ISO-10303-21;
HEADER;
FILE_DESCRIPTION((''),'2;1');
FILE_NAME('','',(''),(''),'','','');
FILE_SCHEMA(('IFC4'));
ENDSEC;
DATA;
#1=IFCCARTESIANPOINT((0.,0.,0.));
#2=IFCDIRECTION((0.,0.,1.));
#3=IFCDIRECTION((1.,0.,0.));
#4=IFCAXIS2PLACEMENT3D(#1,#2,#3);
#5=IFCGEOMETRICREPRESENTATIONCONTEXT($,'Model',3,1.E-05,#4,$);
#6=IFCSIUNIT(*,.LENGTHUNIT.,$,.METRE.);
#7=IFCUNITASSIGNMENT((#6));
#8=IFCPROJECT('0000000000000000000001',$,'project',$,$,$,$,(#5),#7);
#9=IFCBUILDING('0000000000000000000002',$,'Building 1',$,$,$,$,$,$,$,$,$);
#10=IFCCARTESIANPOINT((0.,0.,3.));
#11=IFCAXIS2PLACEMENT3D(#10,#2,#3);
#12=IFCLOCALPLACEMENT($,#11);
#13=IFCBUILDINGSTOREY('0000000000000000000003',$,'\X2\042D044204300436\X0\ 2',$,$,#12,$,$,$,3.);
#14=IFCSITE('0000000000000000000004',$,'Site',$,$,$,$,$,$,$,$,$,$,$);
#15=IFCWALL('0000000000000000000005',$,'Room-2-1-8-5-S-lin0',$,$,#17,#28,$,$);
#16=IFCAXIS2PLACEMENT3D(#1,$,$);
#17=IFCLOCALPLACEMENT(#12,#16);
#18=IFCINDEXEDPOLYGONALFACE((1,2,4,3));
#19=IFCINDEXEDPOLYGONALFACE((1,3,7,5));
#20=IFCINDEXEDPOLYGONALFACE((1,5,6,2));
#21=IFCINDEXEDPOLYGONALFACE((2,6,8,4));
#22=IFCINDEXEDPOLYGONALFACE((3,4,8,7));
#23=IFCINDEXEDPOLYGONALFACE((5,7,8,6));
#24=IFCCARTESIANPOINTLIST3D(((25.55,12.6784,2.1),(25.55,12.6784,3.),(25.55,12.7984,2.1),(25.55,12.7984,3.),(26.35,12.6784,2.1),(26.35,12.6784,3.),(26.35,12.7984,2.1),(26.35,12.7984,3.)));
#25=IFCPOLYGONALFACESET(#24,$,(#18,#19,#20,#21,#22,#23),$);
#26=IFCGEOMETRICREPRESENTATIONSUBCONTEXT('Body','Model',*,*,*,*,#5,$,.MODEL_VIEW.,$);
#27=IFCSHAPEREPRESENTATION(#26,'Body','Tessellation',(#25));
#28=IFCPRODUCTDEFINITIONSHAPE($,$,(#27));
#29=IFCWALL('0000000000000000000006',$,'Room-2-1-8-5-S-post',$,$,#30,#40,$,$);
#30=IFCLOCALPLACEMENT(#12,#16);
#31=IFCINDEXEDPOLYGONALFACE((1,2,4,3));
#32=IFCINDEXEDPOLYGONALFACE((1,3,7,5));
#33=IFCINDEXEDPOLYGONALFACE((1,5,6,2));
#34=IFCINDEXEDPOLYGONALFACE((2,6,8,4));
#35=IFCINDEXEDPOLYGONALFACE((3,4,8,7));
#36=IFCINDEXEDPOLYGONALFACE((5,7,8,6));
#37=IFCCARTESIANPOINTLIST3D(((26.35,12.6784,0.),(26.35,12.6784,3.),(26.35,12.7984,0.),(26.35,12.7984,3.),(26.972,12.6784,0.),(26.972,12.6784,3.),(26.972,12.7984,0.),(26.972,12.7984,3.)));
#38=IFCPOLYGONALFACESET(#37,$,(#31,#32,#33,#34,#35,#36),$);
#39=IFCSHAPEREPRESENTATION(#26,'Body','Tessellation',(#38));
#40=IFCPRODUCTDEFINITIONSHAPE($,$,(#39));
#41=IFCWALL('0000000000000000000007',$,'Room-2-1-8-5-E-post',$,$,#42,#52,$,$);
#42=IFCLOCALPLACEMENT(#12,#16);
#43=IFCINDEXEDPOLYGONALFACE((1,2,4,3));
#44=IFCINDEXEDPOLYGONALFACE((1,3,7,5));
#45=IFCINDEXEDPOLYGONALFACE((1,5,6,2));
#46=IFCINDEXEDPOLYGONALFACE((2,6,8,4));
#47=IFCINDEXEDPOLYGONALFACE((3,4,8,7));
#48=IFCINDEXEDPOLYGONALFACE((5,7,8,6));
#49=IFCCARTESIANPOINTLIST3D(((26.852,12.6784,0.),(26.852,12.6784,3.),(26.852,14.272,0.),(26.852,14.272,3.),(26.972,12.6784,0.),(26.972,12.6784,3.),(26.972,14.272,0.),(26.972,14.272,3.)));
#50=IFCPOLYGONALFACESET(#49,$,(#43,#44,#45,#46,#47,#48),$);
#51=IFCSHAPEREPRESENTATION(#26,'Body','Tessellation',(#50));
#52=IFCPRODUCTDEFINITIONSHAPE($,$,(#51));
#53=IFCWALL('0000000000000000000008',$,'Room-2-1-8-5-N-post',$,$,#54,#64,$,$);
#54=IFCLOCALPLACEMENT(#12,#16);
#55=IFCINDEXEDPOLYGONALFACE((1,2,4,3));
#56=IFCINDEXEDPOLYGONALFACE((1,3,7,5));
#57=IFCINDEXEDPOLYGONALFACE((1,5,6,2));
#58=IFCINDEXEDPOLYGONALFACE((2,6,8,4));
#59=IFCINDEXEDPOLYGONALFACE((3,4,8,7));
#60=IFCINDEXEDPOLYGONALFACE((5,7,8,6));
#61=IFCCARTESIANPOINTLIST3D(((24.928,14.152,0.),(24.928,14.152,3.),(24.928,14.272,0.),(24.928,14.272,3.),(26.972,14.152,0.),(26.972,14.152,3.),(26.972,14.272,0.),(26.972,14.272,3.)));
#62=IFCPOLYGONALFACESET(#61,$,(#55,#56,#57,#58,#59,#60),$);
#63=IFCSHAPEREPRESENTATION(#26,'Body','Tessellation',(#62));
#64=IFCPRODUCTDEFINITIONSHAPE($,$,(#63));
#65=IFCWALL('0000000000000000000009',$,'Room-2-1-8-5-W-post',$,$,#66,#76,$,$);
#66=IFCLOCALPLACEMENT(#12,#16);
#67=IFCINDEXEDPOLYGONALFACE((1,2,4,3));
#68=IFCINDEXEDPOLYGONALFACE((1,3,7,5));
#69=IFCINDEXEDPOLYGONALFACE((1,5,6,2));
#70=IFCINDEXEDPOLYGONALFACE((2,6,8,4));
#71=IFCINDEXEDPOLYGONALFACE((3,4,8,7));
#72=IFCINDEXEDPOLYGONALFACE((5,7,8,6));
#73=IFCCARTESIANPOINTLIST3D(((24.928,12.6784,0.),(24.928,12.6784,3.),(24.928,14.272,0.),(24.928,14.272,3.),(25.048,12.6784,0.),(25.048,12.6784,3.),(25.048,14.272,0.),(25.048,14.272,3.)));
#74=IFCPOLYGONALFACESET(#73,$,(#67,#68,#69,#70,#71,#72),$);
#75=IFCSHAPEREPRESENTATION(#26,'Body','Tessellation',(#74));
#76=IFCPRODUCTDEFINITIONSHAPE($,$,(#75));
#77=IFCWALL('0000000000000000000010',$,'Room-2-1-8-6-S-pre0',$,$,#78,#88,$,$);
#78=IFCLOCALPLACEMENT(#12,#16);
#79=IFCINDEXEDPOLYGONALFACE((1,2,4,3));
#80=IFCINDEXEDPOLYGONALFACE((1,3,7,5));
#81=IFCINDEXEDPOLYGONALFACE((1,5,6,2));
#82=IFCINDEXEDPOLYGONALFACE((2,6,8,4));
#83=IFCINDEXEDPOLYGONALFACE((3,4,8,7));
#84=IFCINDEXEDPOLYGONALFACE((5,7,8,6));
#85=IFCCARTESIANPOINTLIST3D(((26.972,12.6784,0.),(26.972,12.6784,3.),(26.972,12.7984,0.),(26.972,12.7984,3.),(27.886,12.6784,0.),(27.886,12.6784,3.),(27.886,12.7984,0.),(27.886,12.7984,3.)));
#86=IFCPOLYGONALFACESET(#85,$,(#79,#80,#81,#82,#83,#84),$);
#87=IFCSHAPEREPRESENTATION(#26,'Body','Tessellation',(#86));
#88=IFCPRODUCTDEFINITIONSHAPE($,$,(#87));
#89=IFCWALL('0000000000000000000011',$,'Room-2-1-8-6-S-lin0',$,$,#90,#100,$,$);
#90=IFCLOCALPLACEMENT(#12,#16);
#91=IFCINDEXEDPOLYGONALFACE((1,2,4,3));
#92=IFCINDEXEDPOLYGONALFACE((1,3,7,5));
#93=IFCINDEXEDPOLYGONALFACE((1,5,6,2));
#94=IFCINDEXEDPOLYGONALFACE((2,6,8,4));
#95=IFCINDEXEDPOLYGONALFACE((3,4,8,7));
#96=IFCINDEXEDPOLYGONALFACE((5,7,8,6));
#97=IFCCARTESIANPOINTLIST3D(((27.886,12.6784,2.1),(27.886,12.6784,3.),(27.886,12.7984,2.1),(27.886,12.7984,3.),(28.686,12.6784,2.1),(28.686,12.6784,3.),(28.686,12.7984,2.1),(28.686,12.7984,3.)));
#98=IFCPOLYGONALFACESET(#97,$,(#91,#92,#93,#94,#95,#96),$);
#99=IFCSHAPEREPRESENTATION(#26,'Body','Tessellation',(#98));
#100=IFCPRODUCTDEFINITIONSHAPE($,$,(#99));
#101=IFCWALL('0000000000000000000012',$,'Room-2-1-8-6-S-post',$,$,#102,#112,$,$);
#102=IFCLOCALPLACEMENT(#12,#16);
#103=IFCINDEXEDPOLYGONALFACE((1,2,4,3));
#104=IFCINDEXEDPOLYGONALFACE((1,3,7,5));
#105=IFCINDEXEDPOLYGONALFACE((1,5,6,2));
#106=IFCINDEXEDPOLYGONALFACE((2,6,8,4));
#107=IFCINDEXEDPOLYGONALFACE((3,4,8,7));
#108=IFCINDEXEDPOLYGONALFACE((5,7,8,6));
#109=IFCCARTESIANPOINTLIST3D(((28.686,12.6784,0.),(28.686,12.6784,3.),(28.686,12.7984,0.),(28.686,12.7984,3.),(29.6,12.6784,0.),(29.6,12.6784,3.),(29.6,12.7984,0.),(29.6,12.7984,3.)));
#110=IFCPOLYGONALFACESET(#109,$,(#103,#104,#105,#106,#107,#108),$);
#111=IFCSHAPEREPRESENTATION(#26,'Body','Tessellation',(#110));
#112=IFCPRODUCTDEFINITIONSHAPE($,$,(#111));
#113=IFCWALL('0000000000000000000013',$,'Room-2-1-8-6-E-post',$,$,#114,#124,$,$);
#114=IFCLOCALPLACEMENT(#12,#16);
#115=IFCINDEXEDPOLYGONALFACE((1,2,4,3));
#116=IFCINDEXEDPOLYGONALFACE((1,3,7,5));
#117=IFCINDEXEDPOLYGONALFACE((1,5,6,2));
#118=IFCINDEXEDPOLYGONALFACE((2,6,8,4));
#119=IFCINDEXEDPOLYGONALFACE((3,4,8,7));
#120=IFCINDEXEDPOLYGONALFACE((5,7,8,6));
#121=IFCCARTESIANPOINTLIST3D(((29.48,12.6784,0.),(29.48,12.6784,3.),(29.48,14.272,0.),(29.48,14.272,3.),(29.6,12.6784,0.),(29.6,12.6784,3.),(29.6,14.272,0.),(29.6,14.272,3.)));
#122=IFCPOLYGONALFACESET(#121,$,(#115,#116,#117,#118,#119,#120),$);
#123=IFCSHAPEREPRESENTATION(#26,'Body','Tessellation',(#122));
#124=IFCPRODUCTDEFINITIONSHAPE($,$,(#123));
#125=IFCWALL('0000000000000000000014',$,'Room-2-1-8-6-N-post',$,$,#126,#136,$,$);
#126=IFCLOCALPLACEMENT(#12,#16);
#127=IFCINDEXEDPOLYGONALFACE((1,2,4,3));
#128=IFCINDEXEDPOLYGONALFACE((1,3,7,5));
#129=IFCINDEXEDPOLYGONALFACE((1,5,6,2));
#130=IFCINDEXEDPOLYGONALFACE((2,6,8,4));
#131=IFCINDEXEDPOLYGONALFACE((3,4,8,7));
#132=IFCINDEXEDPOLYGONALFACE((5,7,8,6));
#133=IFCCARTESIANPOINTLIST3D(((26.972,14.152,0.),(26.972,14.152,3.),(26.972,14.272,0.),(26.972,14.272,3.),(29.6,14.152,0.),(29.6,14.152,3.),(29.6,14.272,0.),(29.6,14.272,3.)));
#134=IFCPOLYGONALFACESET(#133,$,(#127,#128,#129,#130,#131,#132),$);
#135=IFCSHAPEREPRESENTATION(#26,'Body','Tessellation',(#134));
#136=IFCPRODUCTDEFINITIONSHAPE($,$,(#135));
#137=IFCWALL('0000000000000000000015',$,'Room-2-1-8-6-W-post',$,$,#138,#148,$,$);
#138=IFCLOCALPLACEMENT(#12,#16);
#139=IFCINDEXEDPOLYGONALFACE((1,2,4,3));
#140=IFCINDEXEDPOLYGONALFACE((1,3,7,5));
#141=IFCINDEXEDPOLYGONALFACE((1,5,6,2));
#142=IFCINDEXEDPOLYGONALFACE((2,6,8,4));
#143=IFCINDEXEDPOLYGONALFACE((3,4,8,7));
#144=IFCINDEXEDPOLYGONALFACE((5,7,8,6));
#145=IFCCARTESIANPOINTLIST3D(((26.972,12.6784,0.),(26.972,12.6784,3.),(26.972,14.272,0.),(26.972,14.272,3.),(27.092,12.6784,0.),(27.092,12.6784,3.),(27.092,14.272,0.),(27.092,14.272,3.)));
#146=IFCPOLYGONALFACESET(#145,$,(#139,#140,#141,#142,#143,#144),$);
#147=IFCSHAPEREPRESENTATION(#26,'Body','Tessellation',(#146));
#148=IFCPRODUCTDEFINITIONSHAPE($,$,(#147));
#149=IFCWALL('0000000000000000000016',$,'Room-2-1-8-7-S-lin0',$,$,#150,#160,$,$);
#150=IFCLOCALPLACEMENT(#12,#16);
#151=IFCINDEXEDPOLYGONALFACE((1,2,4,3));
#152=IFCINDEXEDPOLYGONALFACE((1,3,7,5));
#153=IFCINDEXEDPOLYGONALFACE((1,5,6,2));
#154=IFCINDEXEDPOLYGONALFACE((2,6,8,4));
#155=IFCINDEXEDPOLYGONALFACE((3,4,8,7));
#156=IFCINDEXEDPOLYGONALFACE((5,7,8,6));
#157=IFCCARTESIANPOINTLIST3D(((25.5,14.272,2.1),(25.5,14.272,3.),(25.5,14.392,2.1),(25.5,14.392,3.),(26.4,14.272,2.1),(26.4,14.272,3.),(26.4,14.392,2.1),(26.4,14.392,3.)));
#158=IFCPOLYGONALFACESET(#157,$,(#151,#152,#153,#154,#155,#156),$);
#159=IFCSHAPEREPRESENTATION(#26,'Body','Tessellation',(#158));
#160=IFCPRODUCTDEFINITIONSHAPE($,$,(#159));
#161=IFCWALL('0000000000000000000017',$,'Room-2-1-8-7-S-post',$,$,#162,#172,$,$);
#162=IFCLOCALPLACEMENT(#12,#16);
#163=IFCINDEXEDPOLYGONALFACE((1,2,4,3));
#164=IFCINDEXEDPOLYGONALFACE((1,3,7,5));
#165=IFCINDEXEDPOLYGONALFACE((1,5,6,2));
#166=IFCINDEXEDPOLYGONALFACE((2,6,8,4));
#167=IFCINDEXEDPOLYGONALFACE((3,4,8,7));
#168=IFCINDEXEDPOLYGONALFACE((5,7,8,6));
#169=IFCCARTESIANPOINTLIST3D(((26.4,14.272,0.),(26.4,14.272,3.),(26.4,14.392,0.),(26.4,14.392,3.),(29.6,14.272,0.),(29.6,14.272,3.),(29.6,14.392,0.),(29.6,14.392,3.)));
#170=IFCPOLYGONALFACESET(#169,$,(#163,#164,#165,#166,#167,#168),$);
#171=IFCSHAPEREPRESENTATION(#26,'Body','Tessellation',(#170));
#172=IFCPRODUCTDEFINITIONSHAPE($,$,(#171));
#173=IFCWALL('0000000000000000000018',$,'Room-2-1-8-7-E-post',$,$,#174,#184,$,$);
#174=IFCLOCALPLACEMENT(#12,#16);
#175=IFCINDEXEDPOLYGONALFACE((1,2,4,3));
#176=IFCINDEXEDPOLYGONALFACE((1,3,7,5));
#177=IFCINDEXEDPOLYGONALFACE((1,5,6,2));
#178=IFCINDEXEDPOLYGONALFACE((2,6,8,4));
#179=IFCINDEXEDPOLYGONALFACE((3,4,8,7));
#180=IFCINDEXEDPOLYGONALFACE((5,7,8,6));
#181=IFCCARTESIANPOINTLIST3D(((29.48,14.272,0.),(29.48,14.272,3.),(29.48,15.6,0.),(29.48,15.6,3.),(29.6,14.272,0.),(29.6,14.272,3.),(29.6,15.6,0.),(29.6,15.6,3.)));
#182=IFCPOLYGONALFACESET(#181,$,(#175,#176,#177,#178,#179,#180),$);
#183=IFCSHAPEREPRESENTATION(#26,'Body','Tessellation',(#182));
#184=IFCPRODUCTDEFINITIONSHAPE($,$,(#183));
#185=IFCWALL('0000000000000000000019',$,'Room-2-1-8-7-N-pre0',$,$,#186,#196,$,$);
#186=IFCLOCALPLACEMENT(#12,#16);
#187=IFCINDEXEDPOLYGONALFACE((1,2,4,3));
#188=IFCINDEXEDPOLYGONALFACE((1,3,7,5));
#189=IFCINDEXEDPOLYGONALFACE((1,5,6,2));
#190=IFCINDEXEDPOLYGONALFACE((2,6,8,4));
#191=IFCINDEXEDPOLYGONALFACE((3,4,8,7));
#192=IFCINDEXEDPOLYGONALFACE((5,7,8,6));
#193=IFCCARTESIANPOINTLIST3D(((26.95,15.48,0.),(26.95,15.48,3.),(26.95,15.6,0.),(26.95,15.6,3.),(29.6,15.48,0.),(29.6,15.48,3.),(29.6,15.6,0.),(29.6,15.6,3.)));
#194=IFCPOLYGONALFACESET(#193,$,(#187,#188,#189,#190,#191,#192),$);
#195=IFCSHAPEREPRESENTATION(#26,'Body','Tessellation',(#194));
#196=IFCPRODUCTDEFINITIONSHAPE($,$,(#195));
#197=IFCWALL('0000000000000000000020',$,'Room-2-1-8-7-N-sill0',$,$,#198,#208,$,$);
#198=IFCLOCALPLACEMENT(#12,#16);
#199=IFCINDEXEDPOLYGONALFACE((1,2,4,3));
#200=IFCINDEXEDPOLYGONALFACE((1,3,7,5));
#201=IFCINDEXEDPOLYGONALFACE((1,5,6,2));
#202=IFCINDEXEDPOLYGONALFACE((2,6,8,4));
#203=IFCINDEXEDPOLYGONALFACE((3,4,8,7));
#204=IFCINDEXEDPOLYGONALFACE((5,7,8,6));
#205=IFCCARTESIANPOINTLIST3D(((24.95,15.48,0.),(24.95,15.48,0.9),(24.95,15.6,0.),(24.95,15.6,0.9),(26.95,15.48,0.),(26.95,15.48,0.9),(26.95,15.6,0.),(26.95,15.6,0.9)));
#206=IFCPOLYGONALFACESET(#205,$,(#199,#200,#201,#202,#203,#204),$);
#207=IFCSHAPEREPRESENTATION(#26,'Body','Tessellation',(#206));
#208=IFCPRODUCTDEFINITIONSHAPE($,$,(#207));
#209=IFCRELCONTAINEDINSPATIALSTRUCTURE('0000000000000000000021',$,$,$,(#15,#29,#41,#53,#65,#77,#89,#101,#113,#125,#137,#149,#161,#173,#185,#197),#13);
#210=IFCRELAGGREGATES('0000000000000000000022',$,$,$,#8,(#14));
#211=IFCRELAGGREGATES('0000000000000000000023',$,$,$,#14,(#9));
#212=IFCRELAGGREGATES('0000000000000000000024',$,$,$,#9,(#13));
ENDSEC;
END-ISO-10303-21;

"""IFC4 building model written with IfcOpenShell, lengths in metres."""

from ifc_helpers import new_model, si_unit, frame, origin_with_axes, place, context, subcontext, project, spatial, indexed_curve, outline, extrude, element, save


model = new_model("IFC4")

# Units and contexts
model_context = context("Model", 3, precision=1e-05, world=origin_with_axes())
body_context = subcontext(model_context, "Body", "Model", "MODEL_VIEW")
ifc_project = project(units=[si_unit("LENGTHUNIT", "METRE")], contexts=[model_context])

# Site, building, storey
site = spatial("IfcSite", under=ifc_project, Name="Site")
building = spatial("IfcBuilding", under=site, Name="Building 1")
storey_placement = place(None, frame((0.0, 0.0, 3.0), z_axis=(0.0, 0.0, 1.0), x_axis=(1.0, 0.0, 0.0)))
storey = spatial("IfcBuildingStorey", under=building, at=storey_placement, Name="Этаж 2", Elevation=3.0)

# Walls
wall_1_placement = place(storey_placement, frame((25.55, 12.6784, 2.1), z_axis=(0.0, 0.0, 1.0), x_axis=(1.0, 0.0, 0.0)))
element("IfcWall", 1, at=wall_1_placement, inside=storey, Name="Room-2-1-8-5-S-lin0", context=body_context, shape_type="SweptSolid", body=[
    extrude(outline(indexed_curve([(0.0, 0.0), (0.0, 0.12), (0.8, 0.12), (0.8, 0.0), (0.0, 0.0)], self_intersect=False)), origin_with_axes(), (0.0, 0.0, 1.0), 0.9),
])
wall_2_placement = place(storey_placement, frame((26.35, 12.6784, 0.0), z_axis=(0.0, 0.0, 1.0), x_axis=(1.0, 0.0, 0.0)))
element("IfcWall", 2, at=wall_2_placement, inside=storey, Name="Room-2-1-8-5-S-post", context=body_context, shape_type="SweptSolid", body=[
    extrude(outline(indexed_curve([(0.0, 0.0), (0.0, 0.12), (0.622, 0.12), (0.622, 0.0), (0.0, 0.0)], self_intersect=False)), origin_with_axes(), (0.0, 0.0, 1.0), 3.0),
])
wall_3_placement = place(storey_placement, frame((26.972, 12.6784, 0.0), z_axis=(0.0, 0.0, 1.0), x_axis=(0.0, 1.0, 0.0)))
element("IfcWall", 3, at=wall_3_placement, inside=storey, Name="Room-2-1-8-5-E-post", context=body_context, shape_type="SweptSolid", body=[
    extrude(outline(indexed_curve([(0.0, 0.0), (0.0, 0.12), (1.5936, 0.12), (1.5936, 0.0), (0.0, 0.0)], self_intersect=False)), origin_with_axes(), (0.0, 0.0, 1.0), 3.0),
])
wall_4_placement = place(storey_placement, frame((26.972, 14.272, 0.0), z_axis=(0.0, 0.0, 1.0), x_axis=(-1.0, 0.0, 0.0)))
element("IfcWall", 4, at=wall_4_placement, inside=storey, Name="Room-2-1-8-5-N-post", context=body_context, shape_type="SweptSolid", body=[
    extrude(outline(indexed_curve([(0.0, 0.0), (0.0, 0.12), (2.044, 0.12), (2.044, 0.0), (0.0, 0.0)], self_intersect=False)), origin_with_axes(), (0.0, 0.0, 1.0), 3.0),
])
wall_5_placement = place(storey_placement, frame((24.928, 14.272, 0.0), z_axis=(0.0, 0.0, 1.0), x_axis=(0.0, -1.0, 0.0)))
element("IfcWall", 5, at=wall_5_placement, inside=storey, Name="Room-2-1-8-5-W-post", context=body_context, shape_type="SweptSolid", body=[
    extrude(outline(indexed_curve([(0.0, 0.0), (0.0, 0.12), (1.5936, 0.12), (1.5936, 0.0), (0.0, 0.0)], self_intersect=False)), origin_with_axes(), (0.0, 0.0, 1.0), 3.0),
])
wall_6_placement = place(storey_placement, frame((26.972, 12.6784, 0.0), z_axis=(0.0, 0.0, 1.0), x_axis=(1.0, 0.0, 0.0)))
element("IfcWall", 6, at=wall_6_placement, inside=storey, Name="Room-2-1-8-6-S-pre0", context=body_context, shape_type="SweptSolid", body=[
    extrude(outline(indexed_curve([(0.0, 0.0), (0.0, 0.12), (0.914, 0.12), (0.914, 0.0), (0.0, 0.0)], self_intersect=False)), origin_with_axes(), (0.0, 0.0, 1.0), 3.0),
])
wall_7_placement = place(storey_placement, frame((27.886, 12.6784, 2.1), z_axis=(0.0, 0.0, 1.0), x_axis=(1.0, 0.0, 0.0)))
element("IfcWall", 7, at=wall_7_placement, inside=storey, Name="Room-2-1-8-6-S-lin0", context=body_context, shape_type="SweptSolid", body=[
    extrude(outline(indexed_curve([(0.0, 0.0), (0.0, 0.12), (0.8, 0.12), (0.8, 0.0), (0.0, 0.0)], self_intersect=False)), origin_with_axes(), (0.0, 0.0, 1.0), 0.9),
])
wall_8_placement = place(storey_placement, frame((28.686, 12.6784, 0.0), z_axis=(0.0, 0.0, 1.0), x_axis=(1.0, 0.0, 0.0)))
element("IfcWall", 8, at=wall_8_placement, inside=storey, Name="Room-2-1-8-6-S-post", context=body_context, shape_type="SweptSolid", body=[
    extrude(outline(indexed_curve([(0.0, 0.0), (0.0, 0.12), (0.914, 0.12), (0.914, 0.0), (0.0, 0.0)], self_intersect=False)), origin_with_axes(), (0.0, 0.0, 1.0), 3.0),
])
wall_9_placement = place(storey_placement, frame((29.6, 12.6784, 0.0), z_axis=(0.0, 0.0, 1.0), x_axis=(0.0, 1.0, 0.0)))
element("IfcWall", 9, at=wall_9_placement, inside=storey, Name="Room-2-1-8-6-E-post", context=body_context, shape_type="SweptSolid", body=[
    extrude(outline(indexed_curve([(0.0, 0.0), (0.0, 0.12), (1.5936, 0.12), (1.5936, 0.0), (0.0, 0.0)], self_intersect=False)), origin_with_axes(), (0.0, 0.0, 1.0), 3.0),
])
wall_10_placement = place(storey_placement, frame((29.6, 14.272, 0.0), z_axis=(0.0, 0.0, 1.0), x_axis=(-1.0, 0.0, 0.0)))
element("IfcWall", 10, at=wall_10_placement, inside=storey, Name="Room-2-1-8-6-N-post", context=body_context, shape_type="SweptSolid", body=[
    extrude(outline(indexed_curve([(0.0, 0.0), (0.0, 0.12), (2.628, 0.12), (2.628, 0.0), (0.0, 0.0)], self_intersect=False)), origin_with_axes(), (0.0, 0.0, 1.0), 3.0),
])
wall_11_placement = place(storey_placement, frame((26.972, 14.272, 0.0), z_axis=(0.0, 0.0, 1.0), x_axis=(0.0, -1.0, 0.0)))
element("IfcWall", 11, at=wall_11_placement, inside=storey, Name="Room-2-1-8-6-W-post", context=body_context, shape_type="SweptSolid", body=[
    extrude(outline(indexed_curve([(0.0, 0.0), (0.0, 0.12), (1.5936, 0.12), (1.5936, 0.0), (0.0, 0.0)], self_intersect=False)), origin_with_axes(), (0.0, 0.0, 1.0), 3.0),
])
wall_12_placement = place(storey_placement, frame((25.5, 14.272, 2.1), z_axis=(0.0, 0.0, 1.0), x_axis=(1.0, 0.0, 0.0)))
element("IfcWall", 12, at=wall_12_placement, inside=storey, Name="Room-2-1-8-7-S-lin0", context=body_context, shape_type="SweptSolid", body=[
    extrude(outline(indexed_curve([(0.0, 0.0), (0.0, 0.12), (0.9, 0.12), (0.9, 0.0), (0.0, 0.0)], self_intersect=False)), origin_with_axes(), (0.0, 0.0, 1.0), 0.9),
])
wall_13_placement = place(storey_placement, frame((26.4, 14.272, 0.0), z_axis=(0.0, 0.0, 1.0), x_axis=(1.0, 0.0, 0.0)))
element("IfcWall", 13, at=wall_13_placement, inside=storey, Name="Room-2-1-8-7-S-post", context=body_context, shape_type="SweptSolid", body=[
    extrude(outline(indexed_curve([(0.0, 0.0), (0.0, 0.12), (3.2, 0.12), (3.2, 0.0), (0.0, 0.0)], self_intersect=False)), origin_with_axes(), (0.0, 0.0, 1.0), 3.0),
])
wall_14_placement = place(storey_placement, frame((29.6, 14.272, 0.0), z_axis=(0.0, 0.0, 1.0), x_axis=(0.0, 1.0, 0.0)))
element("IfcWall", 14, at=wall_14_placement, inside=storey, Name="Room-2-1-8-7-E-post", context=body_context, shape_type="SweptSolid", body=[
    extrude(outline(indexed_curve([(0.0, 0.0), (0.0, 0.12), (1.328, 0.12), (1.328, 0.0), (0.0, 0.0)], self_intersect=False)), origin_with_axes(), (0.0, 0.0, 1.0), 3.0),
])
wall_15_placement = place(storey_placement, frame((29.6, 15.6, 0.0), z_axis=(0.0, 0.0, 1.0), x_axis=(-1.0, 0.0, 0.0)))
element("IfcWall", 15, at=wall_15_placement, inside=storey, Name="Room-2-1-8-7-N-pre0", context=body_context, shape_type="SweptSolid", body=[
    extrude(outline(indexed_curve([(0.0, 0.0), (0.0, 0.12), (2.65, 0.12), (2.65, 0.0), (0.0, 0.0)], self_intersect=False)), origin_with_axes(), (0.0, 0.0, 1.0), 3.0),
])
wall_16_placement = place(storey_placement, frame((26.95, 15.6, 0.0), z_axis=(0.0, 0.0, 1.0), x_axis=(-1.0, 0.0, 0.0)))
element("IfcWall", 16, at=wall_16_placement, inside=storey, Name="Room-2-1-8-7-N-sill0", context=body_context, shape_type="SweptSolid", body=[
    extrude(outline(indexed_curve([(0.0, 0.0), (0.0, 0.12), (2.0, 0.12), (2.0, 0.0), (0.0, 0.0)], self_intersect=False)), origin_with_axes(), (0.0, 0.0, 1.0), 0.9),
])

save(model, "model.ifc")
